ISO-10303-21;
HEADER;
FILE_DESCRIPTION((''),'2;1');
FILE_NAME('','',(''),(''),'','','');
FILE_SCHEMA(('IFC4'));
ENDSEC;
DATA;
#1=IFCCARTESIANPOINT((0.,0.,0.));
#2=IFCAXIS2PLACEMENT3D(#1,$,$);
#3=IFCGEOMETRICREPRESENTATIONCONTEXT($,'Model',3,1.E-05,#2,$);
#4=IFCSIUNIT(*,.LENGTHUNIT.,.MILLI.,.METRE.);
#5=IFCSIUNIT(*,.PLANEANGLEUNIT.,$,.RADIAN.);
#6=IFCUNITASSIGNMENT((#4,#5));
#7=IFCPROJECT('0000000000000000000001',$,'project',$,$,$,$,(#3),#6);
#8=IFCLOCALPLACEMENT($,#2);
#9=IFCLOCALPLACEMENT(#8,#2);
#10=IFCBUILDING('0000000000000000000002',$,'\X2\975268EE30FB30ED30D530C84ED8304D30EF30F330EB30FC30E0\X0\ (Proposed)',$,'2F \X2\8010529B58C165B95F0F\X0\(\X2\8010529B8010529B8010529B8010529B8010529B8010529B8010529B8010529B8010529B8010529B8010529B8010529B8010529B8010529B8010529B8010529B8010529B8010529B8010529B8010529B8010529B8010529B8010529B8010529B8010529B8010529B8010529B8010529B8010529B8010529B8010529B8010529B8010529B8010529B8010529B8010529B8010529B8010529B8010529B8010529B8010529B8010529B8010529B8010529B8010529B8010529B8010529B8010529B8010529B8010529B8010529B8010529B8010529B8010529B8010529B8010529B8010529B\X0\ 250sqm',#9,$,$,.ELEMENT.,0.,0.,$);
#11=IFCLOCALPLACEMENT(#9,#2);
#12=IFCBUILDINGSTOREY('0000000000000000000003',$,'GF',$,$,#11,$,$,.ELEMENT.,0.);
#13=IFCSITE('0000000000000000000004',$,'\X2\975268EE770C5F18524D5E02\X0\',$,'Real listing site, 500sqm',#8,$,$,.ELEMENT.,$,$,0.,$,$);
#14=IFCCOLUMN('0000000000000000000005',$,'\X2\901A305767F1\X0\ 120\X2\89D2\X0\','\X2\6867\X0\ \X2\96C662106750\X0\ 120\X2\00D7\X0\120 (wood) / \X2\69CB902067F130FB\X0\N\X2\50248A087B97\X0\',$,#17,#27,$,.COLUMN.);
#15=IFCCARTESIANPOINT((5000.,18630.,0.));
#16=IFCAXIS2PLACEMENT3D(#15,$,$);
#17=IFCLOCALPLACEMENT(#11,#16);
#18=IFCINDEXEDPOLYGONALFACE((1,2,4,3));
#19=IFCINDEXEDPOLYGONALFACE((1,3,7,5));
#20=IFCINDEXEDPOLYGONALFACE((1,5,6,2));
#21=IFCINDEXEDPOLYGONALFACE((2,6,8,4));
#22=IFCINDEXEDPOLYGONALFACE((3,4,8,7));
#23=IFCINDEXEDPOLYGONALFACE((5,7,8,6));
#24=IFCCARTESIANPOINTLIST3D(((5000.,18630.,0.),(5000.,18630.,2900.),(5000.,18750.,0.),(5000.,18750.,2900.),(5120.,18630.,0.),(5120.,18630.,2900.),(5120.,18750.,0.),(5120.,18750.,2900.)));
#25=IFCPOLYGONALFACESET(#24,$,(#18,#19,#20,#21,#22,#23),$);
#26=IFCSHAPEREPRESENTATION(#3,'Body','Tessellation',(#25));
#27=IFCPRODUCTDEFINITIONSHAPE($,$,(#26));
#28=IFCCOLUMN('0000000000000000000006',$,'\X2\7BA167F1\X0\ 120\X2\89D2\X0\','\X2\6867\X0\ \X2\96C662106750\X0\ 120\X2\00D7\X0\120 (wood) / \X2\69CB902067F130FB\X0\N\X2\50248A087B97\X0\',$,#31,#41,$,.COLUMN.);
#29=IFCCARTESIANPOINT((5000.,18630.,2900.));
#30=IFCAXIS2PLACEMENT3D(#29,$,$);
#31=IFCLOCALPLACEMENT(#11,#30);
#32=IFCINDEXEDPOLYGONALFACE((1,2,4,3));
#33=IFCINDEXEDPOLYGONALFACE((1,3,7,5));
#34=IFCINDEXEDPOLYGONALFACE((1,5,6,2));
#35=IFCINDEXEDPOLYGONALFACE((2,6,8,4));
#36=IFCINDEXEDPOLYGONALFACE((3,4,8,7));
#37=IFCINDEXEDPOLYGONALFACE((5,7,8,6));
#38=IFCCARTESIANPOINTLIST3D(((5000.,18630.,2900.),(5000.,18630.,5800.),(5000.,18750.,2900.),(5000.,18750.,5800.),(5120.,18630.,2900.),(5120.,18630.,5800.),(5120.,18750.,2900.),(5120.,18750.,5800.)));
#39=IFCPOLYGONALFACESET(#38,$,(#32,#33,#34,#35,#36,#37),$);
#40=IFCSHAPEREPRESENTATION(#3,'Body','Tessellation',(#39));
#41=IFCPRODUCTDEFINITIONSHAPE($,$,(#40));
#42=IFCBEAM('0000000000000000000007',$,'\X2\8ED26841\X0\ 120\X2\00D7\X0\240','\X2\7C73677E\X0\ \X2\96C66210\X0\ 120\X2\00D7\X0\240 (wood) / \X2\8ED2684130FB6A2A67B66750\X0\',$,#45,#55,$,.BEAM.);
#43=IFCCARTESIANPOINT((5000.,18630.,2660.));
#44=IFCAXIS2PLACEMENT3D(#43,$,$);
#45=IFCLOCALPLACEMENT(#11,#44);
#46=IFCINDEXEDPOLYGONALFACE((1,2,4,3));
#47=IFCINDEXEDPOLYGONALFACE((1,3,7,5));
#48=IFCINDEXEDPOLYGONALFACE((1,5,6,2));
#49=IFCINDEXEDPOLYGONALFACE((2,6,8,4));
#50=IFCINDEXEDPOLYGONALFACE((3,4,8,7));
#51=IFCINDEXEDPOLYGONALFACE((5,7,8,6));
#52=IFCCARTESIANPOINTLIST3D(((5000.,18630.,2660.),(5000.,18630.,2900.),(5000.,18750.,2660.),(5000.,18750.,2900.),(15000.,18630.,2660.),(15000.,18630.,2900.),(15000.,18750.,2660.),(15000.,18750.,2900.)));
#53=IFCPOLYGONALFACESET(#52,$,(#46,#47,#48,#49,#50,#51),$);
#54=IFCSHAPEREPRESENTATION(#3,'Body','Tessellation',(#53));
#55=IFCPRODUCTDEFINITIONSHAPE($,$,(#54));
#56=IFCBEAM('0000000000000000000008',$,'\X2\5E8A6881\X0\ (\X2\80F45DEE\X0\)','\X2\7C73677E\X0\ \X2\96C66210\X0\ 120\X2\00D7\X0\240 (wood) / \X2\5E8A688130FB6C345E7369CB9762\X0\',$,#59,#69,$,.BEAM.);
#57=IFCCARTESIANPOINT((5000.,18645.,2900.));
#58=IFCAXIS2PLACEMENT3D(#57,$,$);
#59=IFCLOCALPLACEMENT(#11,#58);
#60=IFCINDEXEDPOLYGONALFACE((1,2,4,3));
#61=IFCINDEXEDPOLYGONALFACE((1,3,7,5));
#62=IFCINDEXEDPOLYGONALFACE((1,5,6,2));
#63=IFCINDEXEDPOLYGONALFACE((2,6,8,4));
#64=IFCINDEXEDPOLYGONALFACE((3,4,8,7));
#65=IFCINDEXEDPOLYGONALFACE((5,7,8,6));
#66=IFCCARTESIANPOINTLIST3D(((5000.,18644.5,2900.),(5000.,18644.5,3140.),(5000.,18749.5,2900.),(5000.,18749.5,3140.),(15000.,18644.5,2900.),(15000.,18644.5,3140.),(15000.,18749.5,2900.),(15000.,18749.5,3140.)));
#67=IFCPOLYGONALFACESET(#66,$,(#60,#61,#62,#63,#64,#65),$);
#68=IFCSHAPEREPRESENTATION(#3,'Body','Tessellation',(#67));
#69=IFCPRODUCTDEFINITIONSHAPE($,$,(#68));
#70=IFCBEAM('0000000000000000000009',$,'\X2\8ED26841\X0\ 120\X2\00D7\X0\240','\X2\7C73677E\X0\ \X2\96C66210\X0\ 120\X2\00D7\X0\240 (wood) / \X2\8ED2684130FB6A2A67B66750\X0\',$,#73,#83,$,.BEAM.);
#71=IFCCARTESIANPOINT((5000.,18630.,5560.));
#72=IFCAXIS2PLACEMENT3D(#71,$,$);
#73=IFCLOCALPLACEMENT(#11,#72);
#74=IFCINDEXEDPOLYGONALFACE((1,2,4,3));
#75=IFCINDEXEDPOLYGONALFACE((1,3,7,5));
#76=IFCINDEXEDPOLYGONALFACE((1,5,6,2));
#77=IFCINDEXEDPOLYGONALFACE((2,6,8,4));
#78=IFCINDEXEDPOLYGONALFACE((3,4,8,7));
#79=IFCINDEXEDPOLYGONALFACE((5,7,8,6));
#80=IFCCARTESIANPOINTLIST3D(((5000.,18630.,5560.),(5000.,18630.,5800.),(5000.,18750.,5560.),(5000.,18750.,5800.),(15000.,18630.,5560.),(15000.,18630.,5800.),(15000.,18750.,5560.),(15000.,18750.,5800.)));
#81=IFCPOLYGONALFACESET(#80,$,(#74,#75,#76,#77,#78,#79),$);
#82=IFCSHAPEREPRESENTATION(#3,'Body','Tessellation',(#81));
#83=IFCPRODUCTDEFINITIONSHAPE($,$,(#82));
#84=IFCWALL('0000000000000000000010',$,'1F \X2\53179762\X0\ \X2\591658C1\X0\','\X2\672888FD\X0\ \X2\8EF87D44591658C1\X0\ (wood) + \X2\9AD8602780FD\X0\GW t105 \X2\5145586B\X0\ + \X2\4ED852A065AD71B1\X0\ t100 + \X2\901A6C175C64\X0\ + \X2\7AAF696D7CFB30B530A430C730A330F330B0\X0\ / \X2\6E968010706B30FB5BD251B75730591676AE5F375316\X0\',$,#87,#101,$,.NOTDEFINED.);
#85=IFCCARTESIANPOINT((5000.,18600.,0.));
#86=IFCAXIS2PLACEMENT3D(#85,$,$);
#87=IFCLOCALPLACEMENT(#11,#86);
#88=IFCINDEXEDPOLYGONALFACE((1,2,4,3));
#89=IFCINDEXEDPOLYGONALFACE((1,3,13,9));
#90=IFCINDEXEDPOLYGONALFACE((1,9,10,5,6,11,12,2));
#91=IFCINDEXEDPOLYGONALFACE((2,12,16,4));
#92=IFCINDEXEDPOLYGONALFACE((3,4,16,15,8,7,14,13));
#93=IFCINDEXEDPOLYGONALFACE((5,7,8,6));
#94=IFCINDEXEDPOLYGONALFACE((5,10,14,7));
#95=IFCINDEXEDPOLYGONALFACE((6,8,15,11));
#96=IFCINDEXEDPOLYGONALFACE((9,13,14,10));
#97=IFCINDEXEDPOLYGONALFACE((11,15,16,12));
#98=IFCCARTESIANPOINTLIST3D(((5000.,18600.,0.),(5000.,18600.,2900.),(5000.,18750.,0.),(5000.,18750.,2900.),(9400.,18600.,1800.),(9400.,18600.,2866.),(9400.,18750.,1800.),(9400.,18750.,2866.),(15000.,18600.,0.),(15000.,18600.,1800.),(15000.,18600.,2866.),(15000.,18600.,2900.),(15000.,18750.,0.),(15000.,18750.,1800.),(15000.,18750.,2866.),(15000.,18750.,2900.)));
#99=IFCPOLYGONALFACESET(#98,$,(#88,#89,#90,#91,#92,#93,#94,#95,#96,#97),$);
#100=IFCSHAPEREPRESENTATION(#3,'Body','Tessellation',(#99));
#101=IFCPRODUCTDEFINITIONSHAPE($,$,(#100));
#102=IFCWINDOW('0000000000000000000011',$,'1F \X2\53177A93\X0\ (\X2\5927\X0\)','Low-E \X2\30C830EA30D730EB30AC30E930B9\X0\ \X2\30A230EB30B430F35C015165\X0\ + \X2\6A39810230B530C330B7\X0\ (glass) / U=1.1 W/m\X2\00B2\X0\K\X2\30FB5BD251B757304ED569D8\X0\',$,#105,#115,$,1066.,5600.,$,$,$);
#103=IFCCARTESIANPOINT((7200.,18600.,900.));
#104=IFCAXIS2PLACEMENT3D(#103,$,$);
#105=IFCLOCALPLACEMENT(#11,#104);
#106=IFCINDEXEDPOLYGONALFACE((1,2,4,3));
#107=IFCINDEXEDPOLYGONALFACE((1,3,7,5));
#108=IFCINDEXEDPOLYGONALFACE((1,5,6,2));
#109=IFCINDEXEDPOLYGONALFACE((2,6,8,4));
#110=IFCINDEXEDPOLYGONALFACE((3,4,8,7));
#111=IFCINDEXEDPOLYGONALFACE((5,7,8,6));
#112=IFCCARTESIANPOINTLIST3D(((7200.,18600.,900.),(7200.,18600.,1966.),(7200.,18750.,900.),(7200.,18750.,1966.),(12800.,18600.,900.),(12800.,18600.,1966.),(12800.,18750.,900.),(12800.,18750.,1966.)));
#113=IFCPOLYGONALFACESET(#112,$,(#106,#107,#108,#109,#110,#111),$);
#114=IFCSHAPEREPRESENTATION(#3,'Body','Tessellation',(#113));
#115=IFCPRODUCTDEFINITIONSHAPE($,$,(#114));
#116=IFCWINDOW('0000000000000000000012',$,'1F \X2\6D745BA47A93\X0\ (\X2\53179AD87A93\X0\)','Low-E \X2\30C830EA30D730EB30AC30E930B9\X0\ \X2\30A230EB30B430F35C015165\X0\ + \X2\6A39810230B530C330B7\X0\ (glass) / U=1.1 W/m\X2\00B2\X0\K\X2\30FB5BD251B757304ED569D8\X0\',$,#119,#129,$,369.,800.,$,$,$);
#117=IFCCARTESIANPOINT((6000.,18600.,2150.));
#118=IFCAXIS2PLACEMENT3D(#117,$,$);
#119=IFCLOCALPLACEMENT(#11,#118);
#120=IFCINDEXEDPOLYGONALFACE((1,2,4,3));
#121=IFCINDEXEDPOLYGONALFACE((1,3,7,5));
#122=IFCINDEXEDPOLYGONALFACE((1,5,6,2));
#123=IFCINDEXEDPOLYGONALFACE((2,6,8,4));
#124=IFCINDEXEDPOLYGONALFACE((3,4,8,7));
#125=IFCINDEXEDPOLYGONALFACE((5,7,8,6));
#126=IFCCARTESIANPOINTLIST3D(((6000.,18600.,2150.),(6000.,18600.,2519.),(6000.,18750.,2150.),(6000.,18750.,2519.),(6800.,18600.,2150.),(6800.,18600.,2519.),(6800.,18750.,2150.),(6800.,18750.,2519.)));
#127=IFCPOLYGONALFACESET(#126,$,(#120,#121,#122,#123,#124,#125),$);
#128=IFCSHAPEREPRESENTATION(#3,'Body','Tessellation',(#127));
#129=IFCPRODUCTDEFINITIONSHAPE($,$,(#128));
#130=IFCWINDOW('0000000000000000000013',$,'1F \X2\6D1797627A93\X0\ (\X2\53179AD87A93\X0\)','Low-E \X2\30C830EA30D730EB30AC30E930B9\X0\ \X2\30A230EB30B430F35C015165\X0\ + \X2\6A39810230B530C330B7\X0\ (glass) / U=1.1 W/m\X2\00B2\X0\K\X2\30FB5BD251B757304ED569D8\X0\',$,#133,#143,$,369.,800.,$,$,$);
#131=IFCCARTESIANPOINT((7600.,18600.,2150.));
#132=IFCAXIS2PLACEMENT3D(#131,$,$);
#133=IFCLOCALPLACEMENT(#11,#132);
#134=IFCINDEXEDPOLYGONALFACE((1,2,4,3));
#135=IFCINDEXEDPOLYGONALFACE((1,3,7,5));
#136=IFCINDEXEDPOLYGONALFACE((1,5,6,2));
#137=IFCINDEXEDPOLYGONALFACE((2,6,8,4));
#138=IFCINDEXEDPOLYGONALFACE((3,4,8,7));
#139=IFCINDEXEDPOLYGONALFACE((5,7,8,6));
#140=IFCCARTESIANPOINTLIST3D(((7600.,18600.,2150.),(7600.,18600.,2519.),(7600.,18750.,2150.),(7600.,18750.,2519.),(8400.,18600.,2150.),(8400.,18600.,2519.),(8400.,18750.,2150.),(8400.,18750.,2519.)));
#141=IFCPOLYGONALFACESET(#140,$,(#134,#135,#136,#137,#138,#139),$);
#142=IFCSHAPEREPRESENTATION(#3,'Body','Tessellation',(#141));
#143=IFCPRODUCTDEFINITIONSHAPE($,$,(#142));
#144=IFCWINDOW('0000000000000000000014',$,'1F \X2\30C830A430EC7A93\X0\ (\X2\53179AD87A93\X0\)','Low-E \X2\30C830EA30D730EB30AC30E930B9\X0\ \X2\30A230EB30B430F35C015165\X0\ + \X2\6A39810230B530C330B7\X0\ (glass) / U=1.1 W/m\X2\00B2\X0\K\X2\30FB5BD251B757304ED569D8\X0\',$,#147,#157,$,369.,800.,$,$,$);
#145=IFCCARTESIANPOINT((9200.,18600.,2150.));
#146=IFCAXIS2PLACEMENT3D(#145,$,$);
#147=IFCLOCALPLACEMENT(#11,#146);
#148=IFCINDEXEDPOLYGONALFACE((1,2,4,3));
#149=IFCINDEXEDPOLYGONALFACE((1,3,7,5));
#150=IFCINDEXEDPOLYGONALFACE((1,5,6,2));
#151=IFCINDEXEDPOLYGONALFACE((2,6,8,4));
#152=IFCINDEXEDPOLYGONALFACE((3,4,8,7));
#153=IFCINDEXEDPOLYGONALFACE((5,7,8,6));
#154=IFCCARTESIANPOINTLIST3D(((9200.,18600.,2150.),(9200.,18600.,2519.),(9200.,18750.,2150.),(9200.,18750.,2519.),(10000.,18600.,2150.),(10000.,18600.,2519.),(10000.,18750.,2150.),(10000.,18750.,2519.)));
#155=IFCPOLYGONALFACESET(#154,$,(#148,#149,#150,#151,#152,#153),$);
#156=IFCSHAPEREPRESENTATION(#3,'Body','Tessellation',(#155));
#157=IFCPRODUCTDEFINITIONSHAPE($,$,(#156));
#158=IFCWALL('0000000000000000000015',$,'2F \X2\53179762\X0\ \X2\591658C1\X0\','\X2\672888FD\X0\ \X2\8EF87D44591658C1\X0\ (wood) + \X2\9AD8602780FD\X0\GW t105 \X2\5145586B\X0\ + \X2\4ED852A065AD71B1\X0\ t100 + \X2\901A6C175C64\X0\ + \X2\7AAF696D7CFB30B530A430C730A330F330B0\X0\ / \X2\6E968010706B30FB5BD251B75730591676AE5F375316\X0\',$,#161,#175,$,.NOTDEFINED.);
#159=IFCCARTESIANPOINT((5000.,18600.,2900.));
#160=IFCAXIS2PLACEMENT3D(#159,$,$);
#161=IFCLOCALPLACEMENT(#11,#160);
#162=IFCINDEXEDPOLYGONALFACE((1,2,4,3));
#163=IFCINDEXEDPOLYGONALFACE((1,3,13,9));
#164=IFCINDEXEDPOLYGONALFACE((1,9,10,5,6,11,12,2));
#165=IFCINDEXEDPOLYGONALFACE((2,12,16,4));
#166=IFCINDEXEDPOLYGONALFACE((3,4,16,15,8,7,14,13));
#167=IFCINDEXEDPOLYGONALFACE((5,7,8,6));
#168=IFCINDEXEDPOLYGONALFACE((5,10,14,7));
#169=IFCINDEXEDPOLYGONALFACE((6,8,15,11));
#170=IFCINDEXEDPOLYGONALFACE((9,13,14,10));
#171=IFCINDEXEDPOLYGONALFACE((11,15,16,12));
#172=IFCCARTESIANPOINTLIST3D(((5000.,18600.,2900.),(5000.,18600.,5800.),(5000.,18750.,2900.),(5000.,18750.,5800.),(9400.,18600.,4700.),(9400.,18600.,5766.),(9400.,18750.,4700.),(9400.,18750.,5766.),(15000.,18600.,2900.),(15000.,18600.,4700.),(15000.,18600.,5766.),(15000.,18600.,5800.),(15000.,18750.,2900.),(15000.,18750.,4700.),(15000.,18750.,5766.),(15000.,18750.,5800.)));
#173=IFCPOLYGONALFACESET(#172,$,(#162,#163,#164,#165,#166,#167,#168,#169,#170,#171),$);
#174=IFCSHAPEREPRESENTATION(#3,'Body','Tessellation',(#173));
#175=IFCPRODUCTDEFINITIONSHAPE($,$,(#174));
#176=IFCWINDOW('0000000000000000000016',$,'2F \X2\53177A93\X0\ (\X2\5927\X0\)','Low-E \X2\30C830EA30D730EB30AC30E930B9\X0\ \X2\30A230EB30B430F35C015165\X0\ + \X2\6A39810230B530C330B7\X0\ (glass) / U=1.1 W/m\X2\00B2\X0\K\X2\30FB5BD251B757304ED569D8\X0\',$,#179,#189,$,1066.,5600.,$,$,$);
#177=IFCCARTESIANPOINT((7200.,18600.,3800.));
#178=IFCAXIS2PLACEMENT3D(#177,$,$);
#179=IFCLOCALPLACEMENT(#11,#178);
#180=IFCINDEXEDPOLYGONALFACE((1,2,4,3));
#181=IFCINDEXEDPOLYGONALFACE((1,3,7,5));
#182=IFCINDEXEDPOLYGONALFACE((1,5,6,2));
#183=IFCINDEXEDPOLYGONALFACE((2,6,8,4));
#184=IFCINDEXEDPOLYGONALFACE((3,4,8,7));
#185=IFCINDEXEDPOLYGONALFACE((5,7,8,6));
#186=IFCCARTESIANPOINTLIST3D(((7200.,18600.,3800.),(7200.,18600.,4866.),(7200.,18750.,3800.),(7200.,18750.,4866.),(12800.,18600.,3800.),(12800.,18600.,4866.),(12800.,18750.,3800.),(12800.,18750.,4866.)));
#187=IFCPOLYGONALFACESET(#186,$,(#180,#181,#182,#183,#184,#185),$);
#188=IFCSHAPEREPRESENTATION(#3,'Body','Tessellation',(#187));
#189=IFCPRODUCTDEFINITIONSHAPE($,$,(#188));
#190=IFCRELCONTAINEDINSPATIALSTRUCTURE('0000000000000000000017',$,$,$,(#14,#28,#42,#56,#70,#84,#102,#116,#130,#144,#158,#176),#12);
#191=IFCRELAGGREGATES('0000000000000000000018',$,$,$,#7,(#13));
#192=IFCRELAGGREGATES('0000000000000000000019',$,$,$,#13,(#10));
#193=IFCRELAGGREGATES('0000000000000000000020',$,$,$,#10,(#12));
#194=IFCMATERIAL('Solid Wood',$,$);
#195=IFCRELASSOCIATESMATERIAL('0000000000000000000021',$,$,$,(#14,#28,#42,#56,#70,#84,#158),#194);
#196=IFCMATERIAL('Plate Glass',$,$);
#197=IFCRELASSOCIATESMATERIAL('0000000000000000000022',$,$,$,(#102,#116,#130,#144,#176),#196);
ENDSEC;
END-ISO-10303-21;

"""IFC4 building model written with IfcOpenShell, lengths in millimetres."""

from ifc_helpers import new_model, si_unit, frame, frame_2d, origin, place, context, project, spatial, rectangle, extrude, material, element, fill, save


model = new_model("IFC4")

# Units and contexts
model_context = context("Model", 3, precision=1e-05, world=origin())
ifc_project = project(units=[si_unit("LENGTHUNIT", "METRE", prefix="MILLI"), si_unit("PLANEANGLEUNIT", "RADIAN")], contexts=[model_context])

# Site, building, storey
site_placement = place(None, origin())
site = spatial("IfcSite", under=ifc_project, at=site_placement, Name="青森県弘前市", ObjectType="Real listing site, 500sqm", CompositionType="ELEMENT", RefElevation=0.0)
building_placement = place(site_placement, origin())
building = spatial("IfcBuilding", under=site, at=building_placement, Name="青森・ロフト付きワンルーム (Proposed)", ObjectType="2F 耐力壁方式(耐力耐力耐力耐力耐力耐力耐力耐力耐力耐力耐力耐力耐力耐力耐力耐力耐力耐力耐力耐力耐力耐力耐力耐力耐力耐力耐力耐力耐力耐力耐力耐力耐力耐力耐力耐力耐力耐力耐力耐力耐力耐力耐力耐力耐力耐力耐力耐力耐力耐力耐力耐力耐力耐力耐力耐力耐力 250sqm", CompositionType="ELEMENT", ElevationOfRefHeight=0.0, ElevationOfTerrain=0.0)
storey_placement = place(building_placement, origin())
storey = spatial("IfcBuildingStorey", under=building, at=storey_placement, Name="GF", CompositionType="ELEMENT", Elevation=0.0)

# Columns
ifc_material_1 = material(Name="Solid Wood")
column_1_placement = place(storey_placement, frame((5000.0, 18630.0, 0.0)))
element("IfcColumn", 1, at=column_1_placement, inside=storey, material=ifc_material_1, Name="通し柱 120角", Description="桧 集成材 120×120 (wood) / 構造柱・N値計算", PredefinedType="COLUMN", context=model_context, shape_type="SweptSolid", body=[
    extrude(rectangle(XDim=120.0, YDim=120.0, at=frame_2d((60.0, 60.0))), frame((5000.0, 18630.0, 0.0)), (0.0, 0.0, 1.0), 2900.0),
])
column_2_placement = place(storey_placement, frame((5000.0, 18630.0, 2900.0)))
element("IfcColumn", 2, at=column_2_placement, inside=storey, material=ifc_material_1, Name="管柱 120角", Description="桧 集成材 120×120 (wood) / 構造柱・N値計算", PredefinedType="COLUMN", context=model_context, shape_type="SweptSolid", body=[
    extrude(rectangle(XDim=120.0, YDim=120.0, at=frame_2d((60.0, 60.0))), frame((5000.0, 18630.0, 2900.0)), (0.0, 0.0, 1.0), 2900.0),
])

# Beams
beam_1_placement = place(storey_placement, frame((5000.0, 18630.0, 2660.0)))
element("IfcBeam", 3, at=beam_1_placement, inside=storey, material=ifc_material_1, Name="軒桁 120×240", Description="米松 集成 120×240 (wood) / 軒桁・横架材", PredefinedType="BEAM", context=model_context, shape_type="SweptSolid", body=[
    extrude(rectangle(XDim=10000.0, YDim=120.0, at=frame_2d((5000.0, 60.0))), frame((5000.0, 18630.0, 2660.0)), (0.0, 0.0, 1.0), 240.0),
])
beam_2_placement = place(storey_placement, frame((5000.0, 18645.0, 2900.0)))
element("IfcBeam", 4, at=beam_2_placement, inside=storey, material=ifc_material_1, Name="床梁 (胴差)", Description="米松 集成 120×240 (wood) / 床梁・水平構面", PredefinedType="BEAM", context=model_context, shape_type="SweptSolid", body=[
    extrude(rectangle(XDim=10000.0, YDim=105.0, at=frame_2d((5000.0, 52.0))), frame((5000.0, 18645.0, 2900.0)), (0.0, 0.0, 1.0), 240.0),
])
beam_3_placement = place(storey_placement, frame((5000.0, 18630.0, 5560.0)))
element("IfcBeam", 5, at=beam_3_placement, inside=storey, material=ifc_material_1, Name="軒桁 120×240", Description="米松 集成 120×240 (wood) / 軒桁・横架材", PredefinedType="BEAM", context=model_context, shape_type="SweptSolid", body=[
    extrude(rectangle(XDim=10000.0, YDim=120.0, at=frame_2d((5000.0, 60.0))), frame((5000.0, 18630.0, 5560.0)), (0.0, 0.0, 1.0), 240.0),
])

# Wall, openings, windows
wall_1_placement = place(storey_placement, frame((5000.0, 18600.0, 0.0)))
wall_1 = element("IfcWall", 6, at=wall_1_placement, inside=storey, material=ifc_material_1, Name="1F 北面 外壁", Description="木製 軸組外壁 (wood) + 高性能GW t105 充填 + 付加断熱 t100 + 通気層 + 窯業系サイディング / 準耐火・寒冷地外皮強化", PredefinedType="NOTDEFINED", context=model_context, shape_type="SweptSolid", body=[
    extrude(rectangle(XDim=10000.0, YDim=150.0, at=frame_2d((5000.0, 75.0))), frame((5000.0, 18600.0, 0.0)), (0.0, 0.0, 1.0), 2900.0),
])
opening_1_placement = place(storey_placement, frame((7200.0, 18600.0, 900.0)))
opening_1 = element("IfcOpeningElement", 7, at=opening_1_placement, cuts=wall_1, PredefinedType="NOTDEFINED", context=model_context, shape_type="SweptSolid", body=[
    extrude(rectangle(XDim=5600.0, YDim=150.0, at=frame_2d((2800.0, 75.0))), frame((7200.0, 18600.0, 900.0)), (0.0, 0.0, 1.0), 1066.0),
])
opening_2_placement = place(storey_placement, frame((6000.0, 18600.0, 2150.0)))
opening_2 = element("IfcOpeningElement", 8, at=opening_2_placement, cuts=wall_1, PredefinedType="NOTDEFINED", context=model_context, shape_type="SweptSolid", body=[
    extrude(rectangle(XDim=800.0, YDim=150.0, at=frame_2d((400.0, 75.0))), frame((6000.0, 18600.0, 2150.0)), (0.0, 0.0, 1.0), 369.0),
])
opening_3_placement = place(storey_placement, frame((7600.0, 18600.0, 2150.0)))
opening_3 = element("IfcOpeningElement", 9, at=opening_3_placement, cuts=wall_1, PredefinedType="NOTDEFINED", context=model_context, shape_type="SweptSolid", body=[
    extrude(rectangle(XDim=800.0, YDim=150.0, at=frame_2d((400.0, 75.0))), frame((7600.0, 18600.0, 2150.0)), (0.0, 0.0, 1.0), 369.0),
])
opening_4_placement = place(storey_placement, frame((9200.0, 18600.0, 2150.0)))
opening_4 = element("IfcOpeningElement", 10, at=opening_4_placement, cuts=wall_1, PredefinedType="NOTDEFINED", context=model_context, shape_type="SweptSolid", body=[
    extrude(rectangle(XDim=800.0, YDim=150.0, at=frame_2d((400.0, 75.0))), frame((9200.0, 18600.0, 2150.0)), (0.0, 0.0, 1.0), 369.0),
])
ifc_material_2 = material(Name="Plate Glass")
window_1_placement = place(storey_placement, frame((7200.0, 18600.0, 900.0)))
window_1 = element("IfcWindow", 11, at=window_1_placement, inside=storey, material=ifc_material_2, Name="1F 北窓 (大)", Description="Low-E トリプルガラス アルゴン封入 + 樹脂サッシ (glass) / U=1.1 W/m²K・寒冷地仕様", OverallHeight=1066.0, OverallWidth=5600.0, context=model_context, shape_type="SweptSolid", body=[
    extrude(rectangle(XDim=5600.0, YDim=150.0, at=frame_2d((2800.0, 75.0))), frame((7200.0, 18600.0, 900.0)), (0.0, 0.0, 1.0), 1066.0),
])
fill(opening_1, window_1)
window_2_placement = place(storey_placement, frame((6000.0, 18600.0, 2150.0)))
window_2 = element("IfcWindow", 12, at=window_2_placement, inside=storey, material=ifc_material_2, Name="1F 浴室窓 (北高窓)", Description="Low-E トリプルガラス アルゴン封入 + 樹脂サッシ (glass) / U=1.1 W/m²K・寒冷地仕様", OverallHeight=369.0, OverallWidth=800.0, context=model_context, shape_type="SweptSolid", body=[
    extrude(rectangle(XDim=800.0, YDim=150.0, at=frame_2d((400.0, 75.0))), frame((6000.0, 18600.0, 2150.0)), (0.0, 0.0, 1.0), 369.0),
])
fill(opening_2, window_2)
window_3_placement = place(storey_placement, frame((7600.0, 18600.0, 2150.0)))
window_3 = element("IfcWindow", 13, at=window_3_placement, inside=storey, material=ifc_material_2, Name="1F 洗面窓 (北高窓)", Description="Low-E トリプルガラス アルゴン封入 + 樹脂サッシ (glass) / U=1.1 W/m²K・寒冷地仕様", OverallHeight=369.0, OverallWidth=800.0, context=model_context, shape_type="SweptSolid", body=[
    extrude(rectangle(XDim=800.0, YDim=150.0, at=frame_2d((400.0, 75.0))), frame((7600.0, 18600.0, 2150.0)), (0.0, 0.0, 1.0), 369.0),
])
fill(opening_3, window_3)
window_4_placement = place(storey_placement, frame((9200.0, 18600.0, 2150.0)))
window_4 = element("IfcWindow", 14, at=window_4_placement, inside=storey, material=ifc_material_2, Name="1F トイレ窓 (北高窓)", Description="Low-E トリプルガラス アルゴン封入 + 樹脂サッシ (glass) / U=1.1 W/m²K・寒冷地仕様", OverallHeight=369.0, OverallWidth=800.0, context=model_context, shape_type="SweptSolid", body=[
    extrude(rectangle(XDim=800.0, YDim=150.0, at=frame_2d((400.0, 75.0))), frame((9200.0, 18600.0, 2150.0)), (0.0, 0.0, 1.0), 369.0),
])
fill(opening_4, window_4)

# Wall, opening, window
wall_2_placement = place(storey_placement, frame((5000.0, 18600.0, 2900.0)))
wall_2 = element("IfcWall", 15, at=wall_2_placement, inside=storey, material=ifc_material_1, Name="2F 北面 外壁", Description="木製 軸組外壁 (wood) + 高性能GW t105 充填 + 付加断熱 t100 + 通気層 + 窯業系サイディング / 準耐火・寒冷地外皮強化", PredefinedType="NOTDEFINED", context=model_context, shape_type="SweptSolid", body=[
    extrude(rectangle(XDim=10000.0, YDim=150.0, at=frame_2d((5000.0, 75.0))), frame((5000.0, 18600.0, 2900.0)), (0.0, 0.0, 1.0), 2900.0),
])
opening_5_placement = place(storey_placement, frame((7200.0, 18600.0, 3800.0)))
opening_5 = element("IfcOpeningElement", 16, at=opening_5_placement, cuts=wall_2, PredefinedType="NOTDEFINED", context=model_context, shape_type="SweptSolid", body=[
    extrude(rectangle(XDim=5600.0, YDim=150.0, at=frame_2d((2800.0, 75.0))), frame((7200.0, 18600.0, 3800.0)), (0.0, 0.0, 1.0), 1066.0),
])
window_5_placement = place(storey_placement, frame((7200.0, 18600.0, 3800.0)))
window_5 = element("IfcWindow", 17, at=window_5_placement, inside=storey, material=ifc_material_2, Name="2F 北窓 (大)", Description="Low-E トリプルガラス アルゴン封入 + 樹脂サッシ (glass) / U=1.1 W/m²K・寒冷地仕様", OverallHeight=1066.0, OverallWidth=5600.0, context=model_context, shape_type="SweptSolid", body=[
    extrude(rectangle(XDim=5600.0, YDim=150.0, at=frame_2d((2800.0, 75.0))), frame((7200.0, 18600.0, 3800.0)), (0.0, 0.0, 1.0), 1066.0),
])
fill(opening_5, window_5)

save(model, "model.ifc")
